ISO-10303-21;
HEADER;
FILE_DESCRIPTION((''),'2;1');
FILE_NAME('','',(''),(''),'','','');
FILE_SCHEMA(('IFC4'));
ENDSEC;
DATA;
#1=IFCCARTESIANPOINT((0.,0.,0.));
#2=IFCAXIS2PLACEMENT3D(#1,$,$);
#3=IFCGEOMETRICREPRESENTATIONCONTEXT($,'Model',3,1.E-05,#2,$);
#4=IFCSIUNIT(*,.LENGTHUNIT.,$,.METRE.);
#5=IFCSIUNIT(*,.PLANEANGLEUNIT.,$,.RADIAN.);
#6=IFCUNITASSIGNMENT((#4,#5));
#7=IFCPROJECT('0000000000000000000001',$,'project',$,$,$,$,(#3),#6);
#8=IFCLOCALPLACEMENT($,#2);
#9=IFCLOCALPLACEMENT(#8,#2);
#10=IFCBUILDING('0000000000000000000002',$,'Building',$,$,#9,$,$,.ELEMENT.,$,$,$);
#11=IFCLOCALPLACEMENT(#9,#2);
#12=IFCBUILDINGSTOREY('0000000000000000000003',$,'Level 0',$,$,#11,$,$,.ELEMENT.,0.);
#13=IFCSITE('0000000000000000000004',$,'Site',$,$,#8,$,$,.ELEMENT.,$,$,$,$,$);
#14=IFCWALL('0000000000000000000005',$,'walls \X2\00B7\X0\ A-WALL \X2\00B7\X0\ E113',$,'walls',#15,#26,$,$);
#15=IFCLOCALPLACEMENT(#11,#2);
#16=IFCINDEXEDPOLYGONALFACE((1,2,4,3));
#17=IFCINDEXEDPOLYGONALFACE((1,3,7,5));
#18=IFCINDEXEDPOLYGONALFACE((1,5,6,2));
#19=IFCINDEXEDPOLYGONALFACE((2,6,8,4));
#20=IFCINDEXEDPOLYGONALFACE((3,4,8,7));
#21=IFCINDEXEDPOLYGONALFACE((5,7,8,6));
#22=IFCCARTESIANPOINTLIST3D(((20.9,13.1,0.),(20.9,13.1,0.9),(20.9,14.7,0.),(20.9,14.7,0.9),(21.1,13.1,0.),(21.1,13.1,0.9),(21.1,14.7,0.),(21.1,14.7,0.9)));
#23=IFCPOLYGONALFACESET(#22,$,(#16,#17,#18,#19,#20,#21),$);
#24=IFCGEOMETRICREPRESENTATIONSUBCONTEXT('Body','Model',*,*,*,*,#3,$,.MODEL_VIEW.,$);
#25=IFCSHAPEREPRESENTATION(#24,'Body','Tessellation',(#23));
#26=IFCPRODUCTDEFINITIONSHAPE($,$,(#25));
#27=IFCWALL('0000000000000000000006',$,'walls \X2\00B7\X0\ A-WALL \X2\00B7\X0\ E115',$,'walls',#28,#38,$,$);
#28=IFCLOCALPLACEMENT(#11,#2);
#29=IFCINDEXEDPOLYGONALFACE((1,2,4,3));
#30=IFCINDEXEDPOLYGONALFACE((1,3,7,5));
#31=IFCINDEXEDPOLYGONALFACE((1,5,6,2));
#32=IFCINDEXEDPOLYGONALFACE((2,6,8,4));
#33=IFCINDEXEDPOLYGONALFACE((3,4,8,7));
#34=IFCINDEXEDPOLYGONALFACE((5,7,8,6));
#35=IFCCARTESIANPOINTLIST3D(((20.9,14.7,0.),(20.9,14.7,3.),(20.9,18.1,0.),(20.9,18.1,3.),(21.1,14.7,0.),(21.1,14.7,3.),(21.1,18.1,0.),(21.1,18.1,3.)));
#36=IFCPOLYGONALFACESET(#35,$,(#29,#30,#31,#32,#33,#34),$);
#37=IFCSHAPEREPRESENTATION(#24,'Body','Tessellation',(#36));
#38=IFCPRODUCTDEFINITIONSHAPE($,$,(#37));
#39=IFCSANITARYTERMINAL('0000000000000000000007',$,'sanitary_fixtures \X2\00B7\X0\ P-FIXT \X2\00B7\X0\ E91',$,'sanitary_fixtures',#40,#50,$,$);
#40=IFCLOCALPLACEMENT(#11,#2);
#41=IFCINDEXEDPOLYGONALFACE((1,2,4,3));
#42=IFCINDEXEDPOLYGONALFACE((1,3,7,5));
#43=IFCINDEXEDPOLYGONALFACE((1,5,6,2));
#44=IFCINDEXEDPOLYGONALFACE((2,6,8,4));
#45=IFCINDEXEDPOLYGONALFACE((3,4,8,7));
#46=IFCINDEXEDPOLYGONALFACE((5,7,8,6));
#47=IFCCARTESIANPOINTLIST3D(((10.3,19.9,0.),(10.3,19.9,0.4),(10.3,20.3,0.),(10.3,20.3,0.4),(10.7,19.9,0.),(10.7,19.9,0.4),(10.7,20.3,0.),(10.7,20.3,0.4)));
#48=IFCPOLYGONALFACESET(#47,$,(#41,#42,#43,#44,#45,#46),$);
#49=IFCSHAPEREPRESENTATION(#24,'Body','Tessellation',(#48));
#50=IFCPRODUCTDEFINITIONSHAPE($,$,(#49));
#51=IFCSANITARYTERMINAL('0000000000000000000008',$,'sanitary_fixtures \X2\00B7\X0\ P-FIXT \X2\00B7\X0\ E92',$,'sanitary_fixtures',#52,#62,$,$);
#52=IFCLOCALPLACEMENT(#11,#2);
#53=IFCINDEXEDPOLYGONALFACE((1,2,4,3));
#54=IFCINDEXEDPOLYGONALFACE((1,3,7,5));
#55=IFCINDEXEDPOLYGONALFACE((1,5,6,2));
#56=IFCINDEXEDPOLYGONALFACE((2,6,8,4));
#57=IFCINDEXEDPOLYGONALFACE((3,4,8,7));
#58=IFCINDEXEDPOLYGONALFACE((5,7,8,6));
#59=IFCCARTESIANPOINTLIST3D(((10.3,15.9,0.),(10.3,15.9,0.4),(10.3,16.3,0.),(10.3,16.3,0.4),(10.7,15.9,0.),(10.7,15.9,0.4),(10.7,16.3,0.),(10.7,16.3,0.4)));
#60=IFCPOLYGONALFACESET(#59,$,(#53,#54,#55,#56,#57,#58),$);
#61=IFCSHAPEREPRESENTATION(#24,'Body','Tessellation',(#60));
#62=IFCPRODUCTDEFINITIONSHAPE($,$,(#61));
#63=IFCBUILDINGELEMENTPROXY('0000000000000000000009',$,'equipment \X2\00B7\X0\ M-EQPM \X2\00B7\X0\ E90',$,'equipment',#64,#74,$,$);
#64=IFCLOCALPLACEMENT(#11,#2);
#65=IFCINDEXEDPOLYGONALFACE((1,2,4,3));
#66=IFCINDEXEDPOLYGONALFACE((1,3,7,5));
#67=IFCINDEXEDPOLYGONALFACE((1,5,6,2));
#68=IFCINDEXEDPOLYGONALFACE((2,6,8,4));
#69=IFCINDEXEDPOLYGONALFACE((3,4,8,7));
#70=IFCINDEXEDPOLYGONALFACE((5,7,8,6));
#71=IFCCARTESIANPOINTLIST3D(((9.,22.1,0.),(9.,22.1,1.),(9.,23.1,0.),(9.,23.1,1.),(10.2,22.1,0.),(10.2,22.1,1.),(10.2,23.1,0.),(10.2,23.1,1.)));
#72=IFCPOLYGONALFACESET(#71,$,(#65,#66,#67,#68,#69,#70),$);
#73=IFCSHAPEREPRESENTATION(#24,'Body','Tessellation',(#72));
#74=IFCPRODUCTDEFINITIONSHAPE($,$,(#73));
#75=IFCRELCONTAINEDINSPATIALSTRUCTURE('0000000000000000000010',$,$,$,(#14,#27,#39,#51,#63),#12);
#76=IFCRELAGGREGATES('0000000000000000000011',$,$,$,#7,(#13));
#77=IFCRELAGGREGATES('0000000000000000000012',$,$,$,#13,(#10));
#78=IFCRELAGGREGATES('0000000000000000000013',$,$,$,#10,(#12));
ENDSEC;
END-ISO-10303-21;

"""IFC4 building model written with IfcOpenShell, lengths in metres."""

from ifc_helpers import new_model, si_unit, frame, origin, place, context, subcontext, project, spatial, polyline, outline, extrude, element, save


model = new_model("IFC4")

# Units and contexts
model_context = context("Model", 3, precision=1e-05, world=origin())
body_context = subcontext(model_context, "Body", "Model", "MODEL_VIEW")
ifc_project = project(units=[si_unit("LENGTHUNIT", "METRE"), si_unit("PLANEANGLEUNIT", "RADIAN")], contexts=[model_context])

# Site, building, storey
site_placement = place(None, origin())
site = spatial("IfcSite", under=ifc_project, at=site_placement, Name="Site", CompositionType="ELEMENT")
building_placement = place(site_placement, origin())
building = spatial("IfcBuilding", under=site, at=building_placement, Name="Building", CompositionType="ELEMENT")
storey_placement = place(building_placement, origin())
storey = spatial("IfcBuildingStorey", under=building, at=storey_placement, Name="Level 0", CompositionType="ELEMENT", Elevation=0.0)

# Wall, opening
wall_1_placement = place(storey_placement, origin())
wall_1 = element("IfcWall", 1, at=wall_1_placement, inside=storey, Name="walls · A-WALL · E113", ObjectType="walls", context=body_context, shape_type="SweptSolid", body=[
    extrude(outline(polyline([(21.1, 13.1), (21.1, 14.7), (20.9, 14.7), (20.9, 13.1), (21.1, 13.1)])), origin(), (0.0, 0.0, 1.0), 0.9),
])
opening_1_placement = place(storey_placement, frame((0.0, 0.0, 0.9)))
element("IfcOpeningElement", 2, at=opening_1_placement, cuts=wall_1, ObjectType="Opening", context=body_context, shape_type="SweptSolid", body=[
    extrude(outline(polyline([(21.1, 13.1), (21.1, 14.7), (20.9, 14.7), (20.9, 13.1), (21.1, 13.1)])), origin(), (0.0, 0.0, 1.0), 1.4),
])

# Wall
wall_2_placement = place(storey_placement, origin())
element("IfcWall", 3, at=wall_2_placement, inside=storey, Name="walls · A-WALL · E115", ObjectType="walls", context=body_context, shape_type="SweptSolid", body=[
    extrude(outline(polyline([(21.1, 14.7), (21.1, 18.1), (20.9, 18.1), (20.9, 14.7), (21.1, 14.7)])), origin(), (0.0, 0.0, 1.0), 3.0),
])

# Sanitary terminals
sanitary_terminal_1_placement = place(storey_placement, origin())
element("IfcSanitaryTerminal", 4, at=sanitary_terminal_1_placement, inside=storey, Name="sanitary_fixtures · P-FIXT · E91", ObjectType="sanitary_fixtures", context=body_context, shape_type="SweptSolid", body=[
    extrude(outline(polyline([(10.3, 19.9), (10.7, 19.9), (10.7, 20.3), (10.3, 20.3), (10.3, 19.9)])), origin(), (0.0, 0.0, 1.0), 0.4),
])
sanitary_terminal_2_placement = place(storey_placement, origin())
element("IfcSanitaryTerminal", 5, at=sanitary_terminal_2_placement, inside=storey, Name="sanitary_fixtures · P-FIXT · E92", ObjectType="sanitary_fixtures", context=body_context, shape_type="SweptSolid", body=[
    extrude(outline(polyline([(10.3, 15.9), (10.7, 15.9), (10.7, 16.3), (10.3, 16.3), (10.3, 15.9)])), origin(), (0.0, 0.0, 1.0), 0.4),
])

# Building element proxy
proxy_placement = place(storey_placement, origin())
element("IfcBuildingElementProxy", 6, at=proxy_placement, inside=storey, Name="equipment · M-EQPM · E90", ObjectType="equipment", context=body_context, shape_type="SweptSolid", body=[
    extrude(outline(polyline([(9.0, 22.1), (10.2, 22.1), (10.2, 23.1), (9.0, 23.1), (9.0, 22.1)])), origin(), (0.0, 0.0, 1.0), 1.0),
])

save(model, "model.ifc")
